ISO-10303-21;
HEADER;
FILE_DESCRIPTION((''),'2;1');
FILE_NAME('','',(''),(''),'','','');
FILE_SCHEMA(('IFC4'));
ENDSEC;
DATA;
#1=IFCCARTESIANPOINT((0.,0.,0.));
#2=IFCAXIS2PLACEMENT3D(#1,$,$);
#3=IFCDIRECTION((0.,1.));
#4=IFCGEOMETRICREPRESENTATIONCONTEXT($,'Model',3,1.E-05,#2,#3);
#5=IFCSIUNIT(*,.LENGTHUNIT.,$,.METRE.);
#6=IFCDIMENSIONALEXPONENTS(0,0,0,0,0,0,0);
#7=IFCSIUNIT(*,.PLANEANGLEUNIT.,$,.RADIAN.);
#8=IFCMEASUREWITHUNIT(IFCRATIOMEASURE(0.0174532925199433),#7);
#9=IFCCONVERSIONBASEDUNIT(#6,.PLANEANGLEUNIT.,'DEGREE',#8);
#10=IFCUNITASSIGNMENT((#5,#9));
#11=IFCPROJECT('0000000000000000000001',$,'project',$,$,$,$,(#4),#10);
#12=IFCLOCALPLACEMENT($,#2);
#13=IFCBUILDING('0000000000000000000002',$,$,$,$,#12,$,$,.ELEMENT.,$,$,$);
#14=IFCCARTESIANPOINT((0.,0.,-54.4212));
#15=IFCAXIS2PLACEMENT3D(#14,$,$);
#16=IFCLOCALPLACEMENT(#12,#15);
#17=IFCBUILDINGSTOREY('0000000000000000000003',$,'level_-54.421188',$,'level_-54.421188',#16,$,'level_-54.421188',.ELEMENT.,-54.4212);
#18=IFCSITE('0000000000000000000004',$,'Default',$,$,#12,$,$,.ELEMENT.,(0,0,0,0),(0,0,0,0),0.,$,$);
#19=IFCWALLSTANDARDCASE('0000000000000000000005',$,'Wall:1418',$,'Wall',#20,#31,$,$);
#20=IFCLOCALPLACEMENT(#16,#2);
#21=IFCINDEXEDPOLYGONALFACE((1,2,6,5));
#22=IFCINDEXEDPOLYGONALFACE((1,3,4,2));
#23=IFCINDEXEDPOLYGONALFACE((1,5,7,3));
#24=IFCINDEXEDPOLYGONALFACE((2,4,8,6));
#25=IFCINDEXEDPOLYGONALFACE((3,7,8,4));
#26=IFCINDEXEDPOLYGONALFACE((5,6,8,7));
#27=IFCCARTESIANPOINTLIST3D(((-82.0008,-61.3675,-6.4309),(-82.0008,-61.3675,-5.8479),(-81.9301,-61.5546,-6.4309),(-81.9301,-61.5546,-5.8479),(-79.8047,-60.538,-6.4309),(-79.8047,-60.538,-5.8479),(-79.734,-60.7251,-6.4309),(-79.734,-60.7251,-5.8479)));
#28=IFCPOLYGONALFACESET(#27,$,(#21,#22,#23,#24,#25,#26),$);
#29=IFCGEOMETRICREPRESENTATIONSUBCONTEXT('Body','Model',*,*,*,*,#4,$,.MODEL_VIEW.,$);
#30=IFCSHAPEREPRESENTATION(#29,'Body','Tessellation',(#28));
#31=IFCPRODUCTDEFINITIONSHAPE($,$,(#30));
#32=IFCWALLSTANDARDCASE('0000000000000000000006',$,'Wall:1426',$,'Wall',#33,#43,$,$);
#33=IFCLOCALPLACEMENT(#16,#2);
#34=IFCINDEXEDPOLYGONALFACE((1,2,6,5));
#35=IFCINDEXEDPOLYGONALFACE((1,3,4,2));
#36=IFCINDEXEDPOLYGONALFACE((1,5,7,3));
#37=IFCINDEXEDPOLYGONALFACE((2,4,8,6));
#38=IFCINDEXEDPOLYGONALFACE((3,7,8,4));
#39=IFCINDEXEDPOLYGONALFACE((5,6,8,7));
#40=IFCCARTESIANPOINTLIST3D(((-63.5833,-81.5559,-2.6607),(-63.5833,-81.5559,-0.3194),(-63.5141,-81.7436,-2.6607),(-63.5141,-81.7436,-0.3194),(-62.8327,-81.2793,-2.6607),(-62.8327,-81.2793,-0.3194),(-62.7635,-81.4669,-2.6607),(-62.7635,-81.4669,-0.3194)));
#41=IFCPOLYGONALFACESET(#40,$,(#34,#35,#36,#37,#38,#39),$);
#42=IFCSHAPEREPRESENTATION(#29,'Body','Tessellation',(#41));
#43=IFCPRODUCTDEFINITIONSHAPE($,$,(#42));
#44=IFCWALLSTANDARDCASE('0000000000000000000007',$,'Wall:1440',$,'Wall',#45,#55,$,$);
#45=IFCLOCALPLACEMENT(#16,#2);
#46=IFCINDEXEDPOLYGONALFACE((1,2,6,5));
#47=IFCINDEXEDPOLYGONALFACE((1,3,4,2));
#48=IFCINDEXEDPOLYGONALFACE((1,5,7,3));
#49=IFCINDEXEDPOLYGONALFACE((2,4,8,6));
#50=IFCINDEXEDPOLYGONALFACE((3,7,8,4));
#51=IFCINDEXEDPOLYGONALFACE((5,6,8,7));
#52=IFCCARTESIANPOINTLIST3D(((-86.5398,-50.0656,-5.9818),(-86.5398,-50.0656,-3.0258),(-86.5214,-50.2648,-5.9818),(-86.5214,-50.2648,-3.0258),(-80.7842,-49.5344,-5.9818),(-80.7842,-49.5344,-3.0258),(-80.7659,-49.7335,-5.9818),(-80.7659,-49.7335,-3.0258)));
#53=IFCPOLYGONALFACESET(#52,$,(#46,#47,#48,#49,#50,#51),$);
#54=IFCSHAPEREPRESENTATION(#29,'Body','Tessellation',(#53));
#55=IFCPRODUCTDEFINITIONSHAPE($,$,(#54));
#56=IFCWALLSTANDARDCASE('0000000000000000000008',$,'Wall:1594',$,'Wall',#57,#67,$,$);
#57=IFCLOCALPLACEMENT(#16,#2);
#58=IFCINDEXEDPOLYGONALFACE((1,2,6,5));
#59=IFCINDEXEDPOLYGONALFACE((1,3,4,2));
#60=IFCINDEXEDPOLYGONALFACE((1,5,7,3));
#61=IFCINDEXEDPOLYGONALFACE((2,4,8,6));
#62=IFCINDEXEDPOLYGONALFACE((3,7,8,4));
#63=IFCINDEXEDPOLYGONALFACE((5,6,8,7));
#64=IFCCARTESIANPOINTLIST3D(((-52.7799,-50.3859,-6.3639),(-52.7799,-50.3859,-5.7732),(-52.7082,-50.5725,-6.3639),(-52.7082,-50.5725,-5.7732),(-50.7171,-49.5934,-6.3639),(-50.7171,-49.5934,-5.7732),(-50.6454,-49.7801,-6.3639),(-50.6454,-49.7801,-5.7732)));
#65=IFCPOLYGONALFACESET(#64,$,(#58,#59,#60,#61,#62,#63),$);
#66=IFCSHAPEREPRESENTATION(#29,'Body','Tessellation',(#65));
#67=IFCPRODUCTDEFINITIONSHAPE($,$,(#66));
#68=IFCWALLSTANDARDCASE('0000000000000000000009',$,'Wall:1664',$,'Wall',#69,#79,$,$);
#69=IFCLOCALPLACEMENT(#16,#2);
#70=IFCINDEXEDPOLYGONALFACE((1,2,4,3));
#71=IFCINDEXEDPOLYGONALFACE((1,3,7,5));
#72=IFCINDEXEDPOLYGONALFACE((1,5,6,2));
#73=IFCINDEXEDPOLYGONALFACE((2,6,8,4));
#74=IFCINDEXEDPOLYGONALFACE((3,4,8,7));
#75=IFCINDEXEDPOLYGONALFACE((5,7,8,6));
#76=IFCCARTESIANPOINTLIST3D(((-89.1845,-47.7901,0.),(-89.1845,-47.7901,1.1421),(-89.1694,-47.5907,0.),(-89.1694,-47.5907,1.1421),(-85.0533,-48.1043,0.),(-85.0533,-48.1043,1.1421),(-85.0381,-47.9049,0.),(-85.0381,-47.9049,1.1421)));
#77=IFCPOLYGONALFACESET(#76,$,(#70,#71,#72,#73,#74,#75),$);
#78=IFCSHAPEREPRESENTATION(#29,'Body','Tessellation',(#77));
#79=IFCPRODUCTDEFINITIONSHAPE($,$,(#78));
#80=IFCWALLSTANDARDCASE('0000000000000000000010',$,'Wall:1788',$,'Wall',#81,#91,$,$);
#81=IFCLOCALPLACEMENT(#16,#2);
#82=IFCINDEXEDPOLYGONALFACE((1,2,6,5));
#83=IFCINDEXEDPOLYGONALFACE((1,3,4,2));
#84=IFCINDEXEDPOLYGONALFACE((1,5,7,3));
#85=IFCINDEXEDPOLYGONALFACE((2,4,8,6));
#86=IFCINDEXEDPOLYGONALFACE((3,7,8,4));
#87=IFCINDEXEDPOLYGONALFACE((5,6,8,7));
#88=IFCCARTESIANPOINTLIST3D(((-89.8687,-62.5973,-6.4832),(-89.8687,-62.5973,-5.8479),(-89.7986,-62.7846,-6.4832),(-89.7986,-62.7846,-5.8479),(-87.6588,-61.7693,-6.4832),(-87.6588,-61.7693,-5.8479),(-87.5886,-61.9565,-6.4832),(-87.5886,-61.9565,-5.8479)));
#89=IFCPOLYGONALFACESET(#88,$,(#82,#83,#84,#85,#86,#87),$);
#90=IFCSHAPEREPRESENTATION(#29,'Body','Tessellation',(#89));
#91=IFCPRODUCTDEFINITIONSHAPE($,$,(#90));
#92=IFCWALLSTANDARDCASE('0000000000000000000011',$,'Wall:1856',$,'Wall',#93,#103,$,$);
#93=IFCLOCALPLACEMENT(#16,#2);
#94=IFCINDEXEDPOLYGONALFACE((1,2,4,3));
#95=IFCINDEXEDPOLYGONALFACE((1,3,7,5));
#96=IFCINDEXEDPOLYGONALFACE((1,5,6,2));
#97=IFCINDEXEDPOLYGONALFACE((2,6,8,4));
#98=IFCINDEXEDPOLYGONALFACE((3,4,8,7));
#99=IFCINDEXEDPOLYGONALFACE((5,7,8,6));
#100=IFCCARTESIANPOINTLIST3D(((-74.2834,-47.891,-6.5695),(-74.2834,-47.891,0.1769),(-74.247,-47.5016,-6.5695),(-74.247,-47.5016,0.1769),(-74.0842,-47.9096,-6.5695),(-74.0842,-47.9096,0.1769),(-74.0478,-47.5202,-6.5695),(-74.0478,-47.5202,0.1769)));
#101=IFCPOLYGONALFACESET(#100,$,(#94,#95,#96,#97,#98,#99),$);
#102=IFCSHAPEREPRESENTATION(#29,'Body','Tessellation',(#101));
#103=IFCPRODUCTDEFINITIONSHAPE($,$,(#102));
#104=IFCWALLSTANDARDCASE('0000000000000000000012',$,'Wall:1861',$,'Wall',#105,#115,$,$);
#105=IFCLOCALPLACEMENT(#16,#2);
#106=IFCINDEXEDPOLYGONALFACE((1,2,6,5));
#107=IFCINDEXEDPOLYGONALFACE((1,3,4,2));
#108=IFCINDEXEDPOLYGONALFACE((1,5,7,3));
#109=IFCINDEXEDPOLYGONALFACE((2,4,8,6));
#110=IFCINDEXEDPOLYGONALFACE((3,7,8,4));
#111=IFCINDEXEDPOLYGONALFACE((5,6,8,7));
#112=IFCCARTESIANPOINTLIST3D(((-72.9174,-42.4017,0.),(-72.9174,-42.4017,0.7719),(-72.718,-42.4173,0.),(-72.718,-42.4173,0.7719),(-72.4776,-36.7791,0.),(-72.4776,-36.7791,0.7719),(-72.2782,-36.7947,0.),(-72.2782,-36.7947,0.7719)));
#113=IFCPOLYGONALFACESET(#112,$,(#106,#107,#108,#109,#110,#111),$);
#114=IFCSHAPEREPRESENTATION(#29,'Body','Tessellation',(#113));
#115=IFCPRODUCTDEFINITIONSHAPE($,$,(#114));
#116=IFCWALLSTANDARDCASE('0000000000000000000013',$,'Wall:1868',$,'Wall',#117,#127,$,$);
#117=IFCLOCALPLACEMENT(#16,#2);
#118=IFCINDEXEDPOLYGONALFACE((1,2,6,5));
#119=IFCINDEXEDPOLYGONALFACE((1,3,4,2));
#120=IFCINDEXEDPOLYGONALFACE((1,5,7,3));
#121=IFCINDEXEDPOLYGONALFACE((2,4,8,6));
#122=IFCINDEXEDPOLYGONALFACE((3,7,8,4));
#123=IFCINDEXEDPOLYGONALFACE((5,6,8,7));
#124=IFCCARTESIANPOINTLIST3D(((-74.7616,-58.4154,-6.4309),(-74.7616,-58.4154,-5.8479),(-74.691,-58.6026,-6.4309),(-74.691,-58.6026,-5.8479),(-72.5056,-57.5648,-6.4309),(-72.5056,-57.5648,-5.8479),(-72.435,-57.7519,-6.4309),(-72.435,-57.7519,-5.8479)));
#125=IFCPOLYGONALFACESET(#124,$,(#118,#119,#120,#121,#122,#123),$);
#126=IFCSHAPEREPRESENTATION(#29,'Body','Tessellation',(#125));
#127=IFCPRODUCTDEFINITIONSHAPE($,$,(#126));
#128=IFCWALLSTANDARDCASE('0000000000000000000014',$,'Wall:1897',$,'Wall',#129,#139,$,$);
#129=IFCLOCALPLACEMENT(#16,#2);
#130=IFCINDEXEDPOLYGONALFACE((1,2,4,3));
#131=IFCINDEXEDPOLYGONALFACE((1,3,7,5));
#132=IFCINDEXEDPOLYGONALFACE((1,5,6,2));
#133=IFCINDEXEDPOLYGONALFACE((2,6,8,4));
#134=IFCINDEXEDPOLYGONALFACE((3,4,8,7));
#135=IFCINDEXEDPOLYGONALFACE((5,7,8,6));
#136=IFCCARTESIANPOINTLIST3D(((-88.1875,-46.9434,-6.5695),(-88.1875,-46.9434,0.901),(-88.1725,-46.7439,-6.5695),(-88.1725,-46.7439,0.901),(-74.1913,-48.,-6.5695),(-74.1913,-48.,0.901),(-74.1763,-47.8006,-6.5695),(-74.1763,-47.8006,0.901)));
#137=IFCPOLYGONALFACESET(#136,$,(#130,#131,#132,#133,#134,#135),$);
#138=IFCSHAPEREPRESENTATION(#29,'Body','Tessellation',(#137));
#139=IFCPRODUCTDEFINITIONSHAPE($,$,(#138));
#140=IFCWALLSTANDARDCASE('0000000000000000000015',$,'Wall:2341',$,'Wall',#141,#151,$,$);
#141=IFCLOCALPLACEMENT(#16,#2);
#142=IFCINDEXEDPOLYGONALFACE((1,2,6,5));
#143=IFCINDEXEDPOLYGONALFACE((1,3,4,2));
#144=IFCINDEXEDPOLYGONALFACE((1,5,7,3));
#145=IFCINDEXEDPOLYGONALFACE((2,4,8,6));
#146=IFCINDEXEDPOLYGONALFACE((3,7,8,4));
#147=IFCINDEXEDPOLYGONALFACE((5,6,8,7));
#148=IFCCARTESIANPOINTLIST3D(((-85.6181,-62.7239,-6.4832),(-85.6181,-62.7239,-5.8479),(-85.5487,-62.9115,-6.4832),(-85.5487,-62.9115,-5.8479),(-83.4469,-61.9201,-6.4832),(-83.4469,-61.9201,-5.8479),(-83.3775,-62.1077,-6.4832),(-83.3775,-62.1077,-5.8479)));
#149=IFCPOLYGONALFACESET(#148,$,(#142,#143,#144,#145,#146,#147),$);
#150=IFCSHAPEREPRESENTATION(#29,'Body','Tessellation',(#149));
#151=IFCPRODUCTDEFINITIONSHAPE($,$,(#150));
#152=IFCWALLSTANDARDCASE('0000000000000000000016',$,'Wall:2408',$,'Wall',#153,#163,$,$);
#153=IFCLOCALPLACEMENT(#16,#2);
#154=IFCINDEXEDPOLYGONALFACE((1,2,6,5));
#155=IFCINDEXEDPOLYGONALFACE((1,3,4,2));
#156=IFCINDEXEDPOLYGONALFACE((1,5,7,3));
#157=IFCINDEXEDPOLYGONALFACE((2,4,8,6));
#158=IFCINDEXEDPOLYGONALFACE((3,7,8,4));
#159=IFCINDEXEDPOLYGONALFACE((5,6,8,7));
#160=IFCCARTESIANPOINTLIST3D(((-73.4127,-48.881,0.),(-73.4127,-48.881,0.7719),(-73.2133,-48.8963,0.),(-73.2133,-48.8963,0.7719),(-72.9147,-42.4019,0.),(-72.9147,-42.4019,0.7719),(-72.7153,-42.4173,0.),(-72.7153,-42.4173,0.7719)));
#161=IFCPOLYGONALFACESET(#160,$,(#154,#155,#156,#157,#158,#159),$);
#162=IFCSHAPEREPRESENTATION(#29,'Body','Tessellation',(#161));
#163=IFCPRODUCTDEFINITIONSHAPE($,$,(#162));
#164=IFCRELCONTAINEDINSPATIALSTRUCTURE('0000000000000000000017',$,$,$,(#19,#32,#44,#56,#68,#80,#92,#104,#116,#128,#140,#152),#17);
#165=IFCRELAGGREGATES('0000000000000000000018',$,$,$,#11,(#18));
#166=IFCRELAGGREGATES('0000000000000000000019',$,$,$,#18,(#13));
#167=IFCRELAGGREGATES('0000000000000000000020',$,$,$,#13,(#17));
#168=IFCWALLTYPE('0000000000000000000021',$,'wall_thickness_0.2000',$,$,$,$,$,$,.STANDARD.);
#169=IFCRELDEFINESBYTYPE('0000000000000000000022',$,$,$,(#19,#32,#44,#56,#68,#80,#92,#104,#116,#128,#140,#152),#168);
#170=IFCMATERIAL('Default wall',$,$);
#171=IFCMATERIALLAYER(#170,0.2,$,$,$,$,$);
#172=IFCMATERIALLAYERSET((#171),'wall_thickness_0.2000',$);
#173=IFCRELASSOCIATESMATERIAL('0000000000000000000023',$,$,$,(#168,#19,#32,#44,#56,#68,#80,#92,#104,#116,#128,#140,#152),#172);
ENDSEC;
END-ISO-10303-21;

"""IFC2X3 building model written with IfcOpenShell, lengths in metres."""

from ifc_helpers import new_model, entity, si_unit, converted_unit, direction, frame, origin, place, context, subcontext, project, spatial, polyline, outline, extrude, material, layer, layer_set, layer_usage, type_object, element, save


model = new_model("IFC2X3")

# Units and contexts
model_context = context("Model", 3, precision=1e-05, world=origin(), true_north=direction((0.0, 1.0)))
body_context = subcontext(model_context, "Body", "Model", "MODEL_VIEW")
ifc_project = project(units=[si_unit("LENGTHUNIT", "METRE"), converted_unit("PLANEANGLEUNIT", "DEGREE", entity("IfcRatioMeasure", 0.0174532925199433), si_unit("PLANEANGLEUNIT", "RADIAN"), dimensions=[0, 0, 0, 0, 0, 0, 0])], contexts=[model_context])

# Site, building, storey
placement_1 = place(None, origin())
site = spatial("IfcSite", under=ifc_project, at=placement_1, Name="Default", CompositionType="ELEMENT", RefLatitude=(0, 0, 0, 0), RefLongitude=(0, 0, 0, 0), RefElevation=0.0)
building = spatial("IfcBuilding", under=site, at=placement_1, CompositionType="ELEMENT")
storey_placement = place(placement_1, frame((0.0, 0.0, -54.4212)))
storey = spatial("IfcBuildingStorey", under=building, at=storey_placement, Name="level_-54.421188", ObjectType="level_-54.421188", LongName="level_-54.421188", CompositionType="ELEMENT", Elevation=-54.4212)

# Walls
ifc_material = material(Name="Default wall")
ifc_layer = layer(ifc_material, 0.2)
ifc_layer_set = layer_set([ifc_layer], Name="wall_thickness_0.2000")
ifc_layer_usage = layer_usage(ifc_layer_set, "AXIS2", "POSITIVE", -0.1)
wall_type = type_object("IfcWallType", Name="wall_thickness_0.2000", PredefinedType="STANDARD", material=ifc_layer_set)
placement_2 = place(placement_1, frame((0.0, 0.0, -60.8521)))
wall_1_placement = place(placement_2, frame((-81.9655, -61.461, 0.0), z_axis=(0.0, 0.0, 1.0), x_axis=(0.9355, 0.353326, 0.0)))
element("IfcWallStandardCase", 1, at=wall_1_placement, inside=storey, type_object=wall_type, material=ifc_layer_usage, Name="Wall:1418", ObjectType="Wall", context=body_context, shape_type="SweptSolid", body=[
    extrude(outline(polyline([(2.3476, -0.1), (2.3476, 0.1), (0.0, 0.1), (0.0, -0.1), (2.3476, -0.1)])), origin(), (0.0, 0.0, 1.0), 0.5829),
])
placement_3 = place(placement_1, frame((0.0, 0.0, -57.0819)))
wall_2_placement = place(placement_3, frame((-62.7981, -81.3731, 0.0), z_axis=(0.0, 0.0, 1.0), x_axis=(-0.938293, -0.345841, 0.0)))
element("IfcWallStandardCase", 2, at=wall_2_placement, inside=storey, type_object=wall_type, material=ifc_layer_usage, Name="Wall:1426", ObjectType="Wall", context=body_context, shape_type="SweptSolid", body=[
    extrude(outline(polyline([(0.8, -0.1), (0.8, 0.1), (0.0, 0.1), (0.0, -0.1), (0.8, -0.1)])), origin(), (0.0, 0.0, 1.0), 2.3413),
])
placement_4 = place(placement_1, frame((0.0, 0.0, -60.403)))
wall_3_placement = place(placement_4, frame((-86.5306, -50.1652, 0.0), z_axis=(0.0, 0.0, 1.0), x_axis=(0.995767, 0.091911, 0.0)))
element("IfcWallStandardCase", 3, at=wall_3_placement, inside=storey, type_object=wall_type, material=ifc_layer_usage, Name="Wall:1440", ObjectType="Wall", context=body_context, shape_type="SweptSolid", body=[
    extrude(outline(polyline([(5.78, -0.1), (5.78, 0.1), (0.0, 0.1), (0.0, -0.1), (5.78, -0.1)])), origin(), (0.0, 0.0, 1.0), 2.956),
])
placement_5 = place(placement_1, frame((0.0, 0.0, -60.7851)))
wall_4_placement = place(placement_5, frame((-52.744, -50.4792, 0.0), z_axis=(0.0, 0.0, 1.0), x_axis=(0.933481, 0.358627, 0.0)))
element("IfcWallStandardCase", 4, at=wall_4_placement, inside=storey, type_object=wall_type, material=ifc_layer_usage, Name="Wall:1594", ObjectType="Wall", context=body_context, shape_type="SweptSolid", body=[
    extrude(outline(polyline([(2.2098, -0.1), (2.2098, 0.1), (0.0, 0.1), (0.0, -0.1), (2.2098, -0.1)])), origin(), (0.0, 0.0, 1.0), 0.5908),
])
wall_5_placement = place(storey_placement, frame((-89.177, -47.6904, 0.0), z_axis=(0.0, 0.0, 1.0), x_axis=(0.99712, -0.075834, 0.0)))
element("IfcWallStandardCase", 5, at=wall_5_placement, inside=storey, type_object=wall_type, material=ifc_layer_usage, Name="Wall:1664", ObjectType="Wall", context=body_context, shape_type="SweptSolid", body=[
    extrude(outline(polyline([(4.1432, -0.1), (4.1432, 0.1), (0.0, 0.1), (0.0, -0.1), (4.1432, -0.1)])), origin(), (0.0, 0.0, 1.0), 1.1421),
])
placement_6 = place(placement_1, frame((0.0, 0.0, -60.9044)))
wall_6_placement = place(placement_6, frame((-89.8336, -62.691, 0.0), z_axis=(0.0, 0.0, 1.0), x_axis=(0.936423, 0.350874, 0.0)))
element("IfcWallStandardCase", 6, at=wall_6_placement, inside=storey, type_object=wall_type, material=ifc_layer_usage, Name="Wall:1788", ObjectType="Wall", context=body_context, shape_type="SweptSolid", body=[
    extrude(outline(polyline([(2.36, -0.1), (2.36, 0.1), (0.0, 0.1), (0.0, -0.1), (2.36, -0.1)])), origin(), (0.0, 0.0, 1.0), 0.6353),
])
placement_7 = place(placement_1, frame((0.0, 0.0, -60.9907)))
wall_7_placement = place(placement_7, frame((-74.1838, -47.9003, 0.0), z_axis=(0.0, 0.0, 1.0), x_axis=(0.093037, 0.995663, 0.0)))
element("IfcWallStandardCase", 7, at=wall_7_placement, inside=storey, type_object=wall_type, material=ifc_layer_usage, Name="Wall:1856", ObjectType="Wall", context=body_context, shape_type="SweptSolid", body=[
    extrude(outline(polyline([(0.3911, -0.1), (0.3911, 0.1), (0.0, 0.1), (0.0, -0.1), (0.3911, -0.1)])), origin(), (0.0, 0.0, 1.0), 6.7464),
])
wall_8_placement = place(storey_placement, frame((-72.8177, -42.4095, 0.0), z_axis=(0.0, 0.0, 1.0), x_axis=(0.077991, 0.996954, 0.0)))
element("IfcWallStandardCase", 8, at=wall_8_placement, inside=storey, type_object=wall_type, material=ifc_layer_usage, Name="Wall:1861", ObjectType="Wall", context=body_context, shape_type="SweptSolid", body=[
    extrude(outline(polyline([(5.6398, -0.1), (5.6398, 0.1), (0.0, 0.1), (0.0, -0.1), (5.6398, -0.1)])), origin(), (0.0, 0.0, 1.0), 0.7719),
])
placement_8 = place(placement_1, frame((0.0, 0.0, -60.8521)))
wall_9_placement = place(placement_8, frame((-74.7263, -58.509, 0.0), z_axis=(0.0, 0.0, 1.0), x_axis=(0.935687, 0.352831, 0.0)))
element("IfcWallStandardCase", 9, at=wall_9_placement, inside=storey, type_object=wall_type, material=ifc_layer_usage, Name="Wall:1868", ObjectType="Wall", context=body_context, shape_type="SweptSolid", body=[
    extrude(outline(polyline([(2.411, -0.1), (2.411, 0.1), (0.0, 0.1), (0.0, -0.1), (2.411, -0.1)])), origin(), (0.0, 0.0, 1.0), 0.5829),
])
placement_9 = place(placement_1, frame((0.0, 0.0, -60.9907)))
wall_10_placement = place(placement_9, frame((-88.18, -46.8436, 0.0), z_axis=(0.0, 0.0, 1.0), x_axis=(0.997162, -0.075282, 0.0)))
element("IfcWallStandardCase", 10, at=wall_10_placement, inside=storey, type_object=wall_type, material=ifc_layer_usage, Name="Wall:1897", ObjectType="Wall", context=body_context, shape_type="SweptSolid", body=[
    extrude(outline(polyline([(14.036, -0.1), (14.036, 0.1), (0.0, 0.1), (0.0, -0.1), (14.036, -0.1)])), origin(), (0.0, 0.0, 1.0), 7.4705),
])
placement_10 = place(placement_1, frame((0.0, 0.0, -60.9044)))
wall_11_placement = place(placement_10, frame((-85.5834, -62.8177, 0.0), z_axis=(0.0, 0.0, 1.0), x_axis=(0.937798, 0.347181, 0.0)))
element("IfcWallStandardCase", 11, at=wall_11_placement, inside=storey, type_object=wall_type, material=ifc_layer_usage, Name="Wall:2341", ObjectType="Wall", context=body_context, shape_type="SweptSolid", body=[
    extrude(outline(polyline([(2.3152, -0.1), (2.3152, 0.1), (0.0, 0.1), (0.0, -0.1), (2.3152, -0.1)])), origin(), (0.0, 0.0, 1.0), 0.6353),
])
wall_12_placement = place(storey_placement, frame((-73.313, -48.8887, 0.0), z_axis=(0.0, 0.0, 1.0), x_axis=(0.07664, 0.997059, 0.0)))
element("IfcWallStandardCase", 12, at=wall_12_placement, inside=storey, type_object=wall_type, material=ifc_layer_usage, Name="Wall:2408", ObjectType="Wall", context=body_context, shape_type="SweptSolid", body=[
    extrude(outline(polyline([(6.4982, -0.1), (6.4982, 0.1), (0.0, 0.1), (0.0, -0.1), (6.4982, -0.1)])), origin(), (0.0, 0.0, 1.0), 0.7719),
])

save(model, "model.ifc")
